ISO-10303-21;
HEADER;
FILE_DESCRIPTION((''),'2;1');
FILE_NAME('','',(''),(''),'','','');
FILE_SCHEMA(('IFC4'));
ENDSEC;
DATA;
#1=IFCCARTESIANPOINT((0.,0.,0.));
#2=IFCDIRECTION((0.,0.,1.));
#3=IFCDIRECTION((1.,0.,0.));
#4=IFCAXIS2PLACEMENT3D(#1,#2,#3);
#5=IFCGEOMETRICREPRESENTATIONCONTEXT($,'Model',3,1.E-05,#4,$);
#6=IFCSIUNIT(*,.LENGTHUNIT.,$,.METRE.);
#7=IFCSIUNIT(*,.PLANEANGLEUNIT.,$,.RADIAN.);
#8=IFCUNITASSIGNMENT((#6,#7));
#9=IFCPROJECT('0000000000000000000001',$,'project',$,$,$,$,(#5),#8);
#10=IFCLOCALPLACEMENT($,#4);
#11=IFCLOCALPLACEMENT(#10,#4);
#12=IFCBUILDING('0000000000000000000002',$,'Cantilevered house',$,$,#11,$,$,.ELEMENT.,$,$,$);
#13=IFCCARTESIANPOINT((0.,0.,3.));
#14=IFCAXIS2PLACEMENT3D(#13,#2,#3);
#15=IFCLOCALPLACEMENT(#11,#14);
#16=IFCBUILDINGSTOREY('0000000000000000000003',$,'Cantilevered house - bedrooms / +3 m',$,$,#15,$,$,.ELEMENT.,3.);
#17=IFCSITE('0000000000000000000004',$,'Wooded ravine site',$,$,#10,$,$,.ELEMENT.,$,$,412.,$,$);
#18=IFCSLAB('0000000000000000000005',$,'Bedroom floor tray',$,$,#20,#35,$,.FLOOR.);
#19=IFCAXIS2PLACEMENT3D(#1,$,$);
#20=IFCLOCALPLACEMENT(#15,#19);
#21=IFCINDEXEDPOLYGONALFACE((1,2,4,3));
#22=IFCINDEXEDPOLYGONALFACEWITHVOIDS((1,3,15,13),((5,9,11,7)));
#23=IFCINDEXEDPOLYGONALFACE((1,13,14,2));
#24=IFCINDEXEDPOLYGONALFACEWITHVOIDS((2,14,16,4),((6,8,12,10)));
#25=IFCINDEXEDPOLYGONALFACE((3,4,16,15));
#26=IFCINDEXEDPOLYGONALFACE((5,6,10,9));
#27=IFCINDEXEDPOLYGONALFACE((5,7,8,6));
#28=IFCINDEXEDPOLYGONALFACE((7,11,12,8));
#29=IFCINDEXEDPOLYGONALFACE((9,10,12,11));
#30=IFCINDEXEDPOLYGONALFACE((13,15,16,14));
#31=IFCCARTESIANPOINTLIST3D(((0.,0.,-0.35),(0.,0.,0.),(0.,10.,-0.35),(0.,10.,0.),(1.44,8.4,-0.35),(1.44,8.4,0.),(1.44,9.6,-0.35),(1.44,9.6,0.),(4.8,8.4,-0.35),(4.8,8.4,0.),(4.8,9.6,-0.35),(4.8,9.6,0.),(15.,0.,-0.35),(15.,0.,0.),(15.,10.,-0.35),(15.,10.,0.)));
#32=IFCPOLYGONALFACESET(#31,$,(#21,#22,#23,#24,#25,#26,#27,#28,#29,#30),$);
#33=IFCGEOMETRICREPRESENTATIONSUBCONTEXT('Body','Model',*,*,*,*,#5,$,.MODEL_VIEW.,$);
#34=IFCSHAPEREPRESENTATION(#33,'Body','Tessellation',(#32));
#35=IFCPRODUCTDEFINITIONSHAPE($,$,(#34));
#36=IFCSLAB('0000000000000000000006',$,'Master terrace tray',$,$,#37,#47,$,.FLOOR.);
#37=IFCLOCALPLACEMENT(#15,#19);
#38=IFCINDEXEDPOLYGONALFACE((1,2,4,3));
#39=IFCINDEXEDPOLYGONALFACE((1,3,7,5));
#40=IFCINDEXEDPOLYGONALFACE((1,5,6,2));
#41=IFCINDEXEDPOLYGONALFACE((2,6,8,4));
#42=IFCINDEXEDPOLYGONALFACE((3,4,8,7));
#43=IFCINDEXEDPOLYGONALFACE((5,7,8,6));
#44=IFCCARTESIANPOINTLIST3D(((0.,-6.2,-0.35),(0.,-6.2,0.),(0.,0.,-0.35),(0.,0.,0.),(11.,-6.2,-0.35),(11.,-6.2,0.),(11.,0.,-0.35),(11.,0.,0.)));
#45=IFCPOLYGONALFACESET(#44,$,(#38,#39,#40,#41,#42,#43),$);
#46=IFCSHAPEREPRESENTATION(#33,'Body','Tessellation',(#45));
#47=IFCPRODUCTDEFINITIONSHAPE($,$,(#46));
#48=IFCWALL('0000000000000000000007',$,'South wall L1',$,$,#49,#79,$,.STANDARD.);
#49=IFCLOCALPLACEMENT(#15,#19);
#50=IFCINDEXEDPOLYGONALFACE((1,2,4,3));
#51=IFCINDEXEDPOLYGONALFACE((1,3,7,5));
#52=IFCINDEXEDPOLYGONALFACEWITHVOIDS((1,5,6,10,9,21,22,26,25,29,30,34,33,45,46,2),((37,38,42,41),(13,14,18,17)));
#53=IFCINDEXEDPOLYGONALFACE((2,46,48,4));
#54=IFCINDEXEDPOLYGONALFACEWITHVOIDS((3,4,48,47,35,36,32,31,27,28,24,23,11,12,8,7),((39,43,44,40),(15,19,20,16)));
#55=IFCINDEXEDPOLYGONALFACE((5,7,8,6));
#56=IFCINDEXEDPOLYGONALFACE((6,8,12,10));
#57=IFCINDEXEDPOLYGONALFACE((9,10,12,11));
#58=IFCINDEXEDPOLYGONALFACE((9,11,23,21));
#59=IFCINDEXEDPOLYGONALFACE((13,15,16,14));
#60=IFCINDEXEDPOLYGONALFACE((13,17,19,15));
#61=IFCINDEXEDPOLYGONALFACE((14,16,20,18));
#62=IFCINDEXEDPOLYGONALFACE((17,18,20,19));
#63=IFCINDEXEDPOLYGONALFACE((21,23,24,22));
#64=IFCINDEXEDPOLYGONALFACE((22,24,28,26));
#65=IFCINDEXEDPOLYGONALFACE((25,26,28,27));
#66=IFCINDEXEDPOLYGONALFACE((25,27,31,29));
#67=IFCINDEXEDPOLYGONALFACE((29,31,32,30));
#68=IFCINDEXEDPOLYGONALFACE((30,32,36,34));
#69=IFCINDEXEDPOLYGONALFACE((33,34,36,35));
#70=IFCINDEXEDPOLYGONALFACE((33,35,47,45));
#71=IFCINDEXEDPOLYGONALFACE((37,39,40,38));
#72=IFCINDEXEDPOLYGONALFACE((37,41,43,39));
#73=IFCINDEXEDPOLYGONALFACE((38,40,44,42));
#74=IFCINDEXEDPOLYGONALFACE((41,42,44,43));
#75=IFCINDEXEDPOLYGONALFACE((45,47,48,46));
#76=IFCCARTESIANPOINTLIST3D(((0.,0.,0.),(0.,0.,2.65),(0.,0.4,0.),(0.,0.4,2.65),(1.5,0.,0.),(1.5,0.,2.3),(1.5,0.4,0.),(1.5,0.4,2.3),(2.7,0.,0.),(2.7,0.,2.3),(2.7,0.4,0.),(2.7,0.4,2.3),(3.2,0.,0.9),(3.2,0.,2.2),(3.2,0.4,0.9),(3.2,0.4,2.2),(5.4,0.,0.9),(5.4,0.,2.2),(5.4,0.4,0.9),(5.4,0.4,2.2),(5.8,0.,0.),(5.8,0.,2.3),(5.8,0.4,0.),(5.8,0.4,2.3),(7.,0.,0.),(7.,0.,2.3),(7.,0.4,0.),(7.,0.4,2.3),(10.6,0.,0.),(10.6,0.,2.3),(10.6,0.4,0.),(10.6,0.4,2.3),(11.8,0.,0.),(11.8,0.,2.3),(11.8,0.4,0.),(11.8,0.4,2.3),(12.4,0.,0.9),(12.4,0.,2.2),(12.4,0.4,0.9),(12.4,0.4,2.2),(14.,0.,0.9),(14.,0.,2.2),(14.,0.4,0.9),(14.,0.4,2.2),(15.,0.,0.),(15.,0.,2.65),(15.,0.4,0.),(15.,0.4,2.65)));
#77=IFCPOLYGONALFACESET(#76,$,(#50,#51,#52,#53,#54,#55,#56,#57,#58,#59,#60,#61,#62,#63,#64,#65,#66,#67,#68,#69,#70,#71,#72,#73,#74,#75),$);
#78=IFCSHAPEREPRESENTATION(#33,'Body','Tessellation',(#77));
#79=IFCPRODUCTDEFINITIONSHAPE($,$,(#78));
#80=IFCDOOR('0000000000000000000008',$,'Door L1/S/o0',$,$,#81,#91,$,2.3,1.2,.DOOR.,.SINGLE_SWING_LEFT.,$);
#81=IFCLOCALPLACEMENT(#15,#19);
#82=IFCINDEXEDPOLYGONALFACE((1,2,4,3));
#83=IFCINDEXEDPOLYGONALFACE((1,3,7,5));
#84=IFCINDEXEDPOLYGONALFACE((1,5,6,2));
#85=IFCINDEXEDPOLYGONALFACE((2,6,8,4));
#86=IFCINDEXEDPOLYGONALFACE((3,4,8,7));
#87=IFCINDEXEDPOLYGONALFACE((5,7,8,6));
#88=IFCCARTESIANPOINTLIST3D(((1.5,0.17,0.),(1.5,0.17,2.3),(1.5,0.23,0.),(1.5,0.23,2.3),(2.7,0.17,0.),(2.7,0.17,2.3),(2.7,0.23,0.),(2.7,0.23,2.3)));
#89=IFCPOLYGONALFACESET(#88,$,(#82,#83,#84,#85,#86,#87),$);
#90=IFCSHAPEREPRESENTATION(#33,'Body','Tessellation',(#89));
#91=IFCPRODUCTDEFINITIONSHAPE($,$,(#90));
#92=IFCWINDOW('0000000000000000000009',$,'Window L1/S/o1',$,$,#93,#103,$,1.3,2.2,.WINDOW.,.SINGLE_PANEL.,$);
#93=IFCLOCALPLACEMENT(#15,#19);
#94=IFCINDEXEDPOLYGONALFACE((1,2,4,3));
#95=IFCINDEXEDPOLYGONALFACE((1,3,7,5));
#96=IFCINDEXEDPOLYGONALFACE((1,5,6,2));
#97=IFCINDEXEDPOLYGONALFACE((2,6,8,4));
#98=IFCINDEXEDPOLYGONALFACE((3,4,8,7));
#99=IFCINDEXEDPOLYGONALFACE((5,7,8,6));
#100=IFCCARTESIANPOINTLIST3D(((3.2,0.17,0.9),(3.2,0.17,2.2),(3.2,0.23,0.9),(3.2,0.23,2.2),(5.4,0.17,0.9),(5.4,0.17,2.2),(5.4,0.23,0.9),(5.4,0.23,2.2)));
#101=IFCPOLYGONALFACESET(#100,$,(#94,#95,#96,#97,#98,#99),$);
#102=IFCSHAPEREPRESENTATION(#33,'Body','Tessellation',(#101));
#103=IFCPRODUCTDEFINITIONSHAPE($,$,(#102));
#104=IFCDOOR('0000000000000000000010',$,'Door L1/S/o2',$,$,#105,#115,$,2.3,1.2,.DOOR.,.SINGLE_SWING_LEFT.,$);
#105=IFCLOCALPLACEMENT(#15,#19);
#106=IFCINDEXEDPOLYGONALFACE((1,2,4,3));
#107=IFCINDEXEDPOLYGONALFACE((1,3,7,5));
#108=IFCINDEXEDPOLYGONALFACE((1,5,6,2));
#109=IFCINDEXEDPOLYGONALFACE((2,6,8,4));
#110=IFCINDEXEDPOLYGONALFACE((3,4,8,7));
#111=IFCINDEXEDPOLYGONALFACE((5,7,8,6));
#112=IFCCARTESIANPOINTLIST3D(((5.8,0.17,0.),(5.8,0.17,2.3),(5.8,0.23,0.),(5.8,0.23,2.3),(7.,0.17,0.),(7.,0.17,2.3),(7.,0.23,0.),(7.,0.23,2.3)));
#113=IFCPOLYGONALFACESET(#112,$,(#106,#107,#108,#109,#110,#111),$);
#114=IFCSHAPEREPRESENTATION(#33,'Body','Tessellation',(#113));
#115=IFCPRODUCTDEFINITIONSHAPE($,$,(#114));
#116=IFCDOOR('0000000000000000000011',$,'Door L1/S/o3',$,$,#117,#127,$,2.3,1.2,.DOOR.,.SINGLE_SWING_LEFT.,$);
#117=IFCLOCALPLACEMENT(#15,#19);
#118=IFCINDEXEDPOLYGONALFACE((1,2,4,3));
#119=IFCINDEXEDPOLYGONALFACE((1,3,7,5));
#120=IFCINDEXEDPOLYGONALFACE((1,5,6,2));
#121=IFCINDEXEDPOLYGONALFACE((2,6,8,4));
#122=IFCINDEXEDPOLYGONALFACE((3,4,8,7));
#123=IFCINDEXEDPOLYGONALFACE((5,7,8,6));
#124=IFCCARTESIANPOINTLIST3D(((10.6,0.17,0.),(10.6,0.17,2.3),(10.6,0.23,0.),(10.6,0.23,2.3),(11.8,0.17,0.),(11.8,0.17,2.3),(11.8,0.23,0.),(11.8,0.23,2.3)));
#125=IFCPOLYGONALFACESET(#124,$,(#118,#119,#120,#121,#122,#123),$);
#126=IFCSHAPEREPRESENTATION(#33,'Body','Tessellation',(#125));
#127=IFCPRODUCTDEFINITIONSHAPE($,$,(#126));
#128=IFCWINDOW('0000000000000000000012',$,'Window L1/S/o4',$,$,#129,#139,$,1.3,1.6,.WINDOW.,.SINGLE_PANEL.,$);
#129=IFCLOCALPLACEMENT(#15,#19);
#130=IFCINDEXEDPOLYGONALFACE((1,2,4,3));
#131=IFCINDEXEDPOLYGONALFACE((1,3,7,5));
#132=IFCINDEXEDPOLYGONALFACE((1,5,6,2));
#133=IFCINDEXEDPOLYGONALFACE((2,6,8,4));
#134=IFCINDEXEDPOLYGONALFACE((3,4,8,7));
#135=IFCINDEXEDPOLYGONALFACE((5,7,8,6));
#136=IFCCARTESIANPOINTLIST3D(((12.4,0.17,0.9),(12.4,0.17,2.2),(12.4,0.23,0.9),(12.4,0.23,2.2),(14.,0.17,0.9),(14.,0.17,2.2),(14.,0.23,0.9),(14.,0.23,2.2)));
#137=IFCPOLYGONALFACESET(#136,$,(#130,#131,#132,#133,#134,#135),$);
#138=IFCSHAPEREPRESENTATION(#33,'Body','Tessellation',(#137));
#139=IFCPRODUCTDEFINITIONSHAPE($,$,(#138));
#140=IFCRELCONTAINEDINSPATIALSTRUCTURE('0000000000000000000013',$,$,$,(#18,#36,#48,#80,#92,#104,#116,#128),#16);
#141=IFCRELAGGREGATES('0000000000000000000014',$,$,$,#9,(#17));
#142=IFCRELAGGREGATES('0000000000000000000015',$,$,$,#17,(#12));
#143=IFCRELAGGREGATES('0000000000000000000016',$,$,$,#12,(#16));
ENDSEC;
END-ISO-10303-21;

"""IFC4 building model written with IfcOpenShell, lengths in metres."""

from ifc_helpers import new_model, si_unit, frame, frame_2d, origin_with_axes, place, context, subcontext, project, spatial, rectangle, extrude, element, fill, save


model = new_model("IFC4")

# Units and contexts
model_context = context("Model", 3, precision=1e-05, world=origin_with_axes())
body_context = subcontext(model_context, "Body", "Model", "MODEL_VIEW")
ifc_project = project(units=[si_unit("LENGTHUNIT", "METRE"), si_unit("PLANEANGLEUNIT", "RADIAN")], contexts=[model_context])

# Site, building, storey
site_placement = place(None, origin_with_axes())
site = spatial("IfcSite", under=ifc_project, at=site_placement, Name="Wooded ravine site", CompositionType="ELEMENT", RefElevation=412.0)
building_placement = place(site_placement, origin_with_axes())
building = spatial("IfcBuilding", under=site, at=building_placement, Name="Cantilevered house", CompositionType="ELEMENT")
storey_placement = place(building_placement, frame((0.0, 0.0, 3.0), z_axis=(0.0, 0.0, 1.0), x_axis=(1.0, 0.0, 0.0)))
storey = spatial("IfcBuildingStorey", under=building, at=storey_placement, Name="Cantilevered house - bedrooms / +3 m", CompositionType="ELEMENT", Elevation=3.0)

# Slab, opening
slab_1_placement = place(storey_placement, origin_with_axes())
slab_1 = element("IfcSlab", 1, at=slab_1_placement, inside=storey, Name="Bedroom floor tray", PredefinedType="FLOOR", context=body_context, shape_type="SweptSolid", body=[
    extrude(rectangle(XDim=15.0, YDim=10.0, at=frame_2d((7.5, 5.0))), frame((0.0, 0.0, -0.35), z_axis=(0.0, 0.0, 1.0), x_axis=(1.0, 0.0, 0.0)), (0.0, 0.0, 1.0), 0.35),
])
opening_1_placement = place(storey_placement, origin_with_axes())
element("IfcOpeningElement", 2, at=opening_1_placement, inside=storey, cuts=slab_1, PredefinedType="OPENING", context=body_context, shape_type="SweptSolid", body=[
    extrude(rectangle(XDim=3.36, YDim=1.2, at=frame_2d((3.12, 9.0))), frame((0.0, 0.0, -0.37), z_axis=(0.0, 0.0, 1.0), x_axis=(1.0, 0.0, 0.0)), (0.0, 0.0, 1.0), 0.39),
])

# Slab
slab_2_placement = place(storey_placement, origin_with_axes())
element("IfcSlab", 3, at=slab_2_placement, inside=storey, Name="Master terrace tray", PredefinedType="FLOOR", context=body_context, shape_type="SweptSolid", body=[
    extrude(rectangle(XDim=11.0, YDim=6.2, at=frame_2d((5.5, -3.1))), frame((0.0, 0.0, -0.35), z_axis=(0.0, 0.0, 1.0), x_axis=(1.0, 0.0, 0.0)), (0.0, 0.0, 1.0), 0.35),
])

# Wall, openings, doors, windows
wall_1_placement = place(storey_placement, origin_with_axes())
wall_1 = element("IfcWall", 4, at=wall_1_placement, inside=storey, Name="South wall L1", PredefinedType="STANDARD", context=body_context, shape_type="SweptSolid", body=[
    extrude(rectangle(XDim=15.0, YDim=0.4, at=frame_2d((7.5, 0.2))), origin_with_axes(), (0.0, 0.0, 1.0), 2.65),
])
opening_2_placement = place(storey_placement, origin_with_axes())
opening_2 = element("IfcOpeningElement", 5, at=opening_2_placement, inside=storey, cuts=wall_1, PredefinedType="OPENING", context=body_context, shape_type="SweptSolid", body=[
    extrude(rectangle(XDim=1.2, YDim=0.44, at=frame_2d((2.1, 0.2))), origin_with_axes(), (0.0, 0.0, 1.0), 2.3),
])
opening_3_placement = place(storey_placement, origin_with_axes())
opening_3 = element("IfcOpeningElement", 6, at=opening_3_placement, inside=storey, cuts=wall_1, PredefinedType="OPENING", context=body_context, shape_type="SweptSolid", body=[
    extrude(rectangle(XDim=2.2, YDim=0.44, at=frame_2d((4.3, 0.2))), frame((0.0, 0.0, 0.9), z_axis=(0.0, 0.0, 1.0), x_axis=(1.0, 0.0, 0.0)), (0.0, 0.0, 1.0), 1.3),
])
opening_4_placement = place(storey_placement, origin_with_axes())
opening_4 = element("IfcOpeningElement", 7, at=opening_4_placement, inside=storey, cuts=wall_1, PredefinedType="OPENING", context=body_context, shape_type="SweptSolid", body=[
    extrude(rectangle(XDim=1.2, YDim=0.44, at=frame_2d((6.4, 0.2))), origin_with_axes(), (0.0, 0.0, 1.0), 2.3),
])
opening_5_placement = place(storey_placement, origin_with_axes())
opening_5 = element("IfcOpeningElement", 8, at=opening_5_placement, inside=storey, cuts=wall_1, PredefinedType="OPENING", context=body_context, shape_type="SweptSolid", body=[
    extrude(rectangle(XDim=1.2, YDim=0.44, at=frame_2d((11.2, 0.2))), origin_with_axes(), (0.0, 0.0, 1.0), 2.3),
])
opening_6_placement = place(storey_placement, origin_with_axes())
opening_6 = element("IfcOpeningElement", 9, at=opening_6_placement, inside=storey, cuts=wall_1, PredefinedType="OPENING", context=body_context, shape_type="SweptSolid", body=[
    extrude(rectangle(XDim=1.6, YDim=0.44, at=frame_2d((13.2, 0.2))), frame((0.0, 0.0, 0.9), z_axis=(0.0, 0.0, 1.0), x_axis=(1.0, 0.0, 0.0)), (0.0, 0.0, 1.0), 1.3),
])
door_1_placement = place(storey_placement, origin_with_axes())
door_1 = element("IfcDoor", 10, at=door_1_placement, inside=storey, Name="Door L1/S/o0", OperationType="SINGLE_SWING_LEFT", OverallHeight=2.3, OverallWidth=1.2, PredefinedType="DOOR", context=body_context, shape_type="SweptSolid", body=[
    extrude(rectangle(XDim=1.2, YDim=0.06, at=frame_2d((2.1, 0.2))), origin_with_axes(), (0.0, 0.0, 1.0), 2.3),
])
fill(opening_2, door_1)
window_1_placement = place(storey_placement, origin_with_axes())
window_1 = element("IfcWindow", 11, at=window_1_placement, inside=storey, Name="Window L1/S/o1", OverallHeight=1.3, OverallWidth=2.2, PartitioningType="SINGLE_PANEL", PredefinedType="WINDOW", context=body_context, shape_type="SweptSolid", body=[
    extrude(rectangle(XDim=2.2, YDim=0.06, at=frame_2d((4.3, 0.2))), frame((0.0, 0.0, 0.9), z_axis=(0.0, 0.0, 1.0), x_axis=(1.0, 0.0, 0.0)), (0.0, 0.0, 1.0), 1.3),
])
fill(opening_3, window_1)
door_2_placement = place(storey_placement, origin_with_axes())
door_2 = element("IfcDoor", 12, at=door_2_placement, inside=storey, Name="Door L1/S/o2", OperationType="SINGLE_SWING_LEFT", OverallHeight=2.3, OverallWidth=1.2, PredefinedType="DOOR", context=body_context, shape_type="SweptSolid", body=[
    extrude(rectangle(XDim=1.2, YDim=0.06, at=frame_2d((6.4, 0.2))), origin_with_axes(), (0.0, 0.0, 1.0), 2.3),
])
fill(opening_4, door_2)
door_3_placement = place(storey_placement, origin_with_axes())
door_3 = element("IfcDoor", 13, at=door_3_placement, inside=storey, Name="Door L1/S/o3", OperationType="SINGLE_SWING_LEFT", OverallHeight=2.3, OverallWidth=1.2, PredefinedType="DOOR", context=body_context, shape_type="SweptSolid", body=[
    extrude(rectangle(XDim=1.2, YDim=0.06, at=frame_2d((11.2, 0.2))), origin_with_axes(), (0.0, 0.0, 1.0), 2.3),
])
fill(opening_5, door_3)
window_2_placement = place(storey_placement, origin_with_axes())
window_2 = element("IfcWindow", 14, at=window_2_placement, inside=storey, Name="Window L1/S/o4", OverallHeight=1.3, OverallWidth=1.6, PartitioningType="SINGLE_PANEL", PredefinedType="WINDOW", context=body_context, shape_type="SweptSolid", body=[
    extrude(rectangle(XDim=1.6, YDim=0.06, at=frame_2d((13.2, 0.2))), frame((0.0, 0.0, 0.9), z_axis=(0.0, 0.0, 1.0), x_axis=(1.0, 0.0, 0.0)), (0.0, 0.0, 1.0), 1.3),
])
fill(opening_6, window_2)

save(model, "model.ifc")
